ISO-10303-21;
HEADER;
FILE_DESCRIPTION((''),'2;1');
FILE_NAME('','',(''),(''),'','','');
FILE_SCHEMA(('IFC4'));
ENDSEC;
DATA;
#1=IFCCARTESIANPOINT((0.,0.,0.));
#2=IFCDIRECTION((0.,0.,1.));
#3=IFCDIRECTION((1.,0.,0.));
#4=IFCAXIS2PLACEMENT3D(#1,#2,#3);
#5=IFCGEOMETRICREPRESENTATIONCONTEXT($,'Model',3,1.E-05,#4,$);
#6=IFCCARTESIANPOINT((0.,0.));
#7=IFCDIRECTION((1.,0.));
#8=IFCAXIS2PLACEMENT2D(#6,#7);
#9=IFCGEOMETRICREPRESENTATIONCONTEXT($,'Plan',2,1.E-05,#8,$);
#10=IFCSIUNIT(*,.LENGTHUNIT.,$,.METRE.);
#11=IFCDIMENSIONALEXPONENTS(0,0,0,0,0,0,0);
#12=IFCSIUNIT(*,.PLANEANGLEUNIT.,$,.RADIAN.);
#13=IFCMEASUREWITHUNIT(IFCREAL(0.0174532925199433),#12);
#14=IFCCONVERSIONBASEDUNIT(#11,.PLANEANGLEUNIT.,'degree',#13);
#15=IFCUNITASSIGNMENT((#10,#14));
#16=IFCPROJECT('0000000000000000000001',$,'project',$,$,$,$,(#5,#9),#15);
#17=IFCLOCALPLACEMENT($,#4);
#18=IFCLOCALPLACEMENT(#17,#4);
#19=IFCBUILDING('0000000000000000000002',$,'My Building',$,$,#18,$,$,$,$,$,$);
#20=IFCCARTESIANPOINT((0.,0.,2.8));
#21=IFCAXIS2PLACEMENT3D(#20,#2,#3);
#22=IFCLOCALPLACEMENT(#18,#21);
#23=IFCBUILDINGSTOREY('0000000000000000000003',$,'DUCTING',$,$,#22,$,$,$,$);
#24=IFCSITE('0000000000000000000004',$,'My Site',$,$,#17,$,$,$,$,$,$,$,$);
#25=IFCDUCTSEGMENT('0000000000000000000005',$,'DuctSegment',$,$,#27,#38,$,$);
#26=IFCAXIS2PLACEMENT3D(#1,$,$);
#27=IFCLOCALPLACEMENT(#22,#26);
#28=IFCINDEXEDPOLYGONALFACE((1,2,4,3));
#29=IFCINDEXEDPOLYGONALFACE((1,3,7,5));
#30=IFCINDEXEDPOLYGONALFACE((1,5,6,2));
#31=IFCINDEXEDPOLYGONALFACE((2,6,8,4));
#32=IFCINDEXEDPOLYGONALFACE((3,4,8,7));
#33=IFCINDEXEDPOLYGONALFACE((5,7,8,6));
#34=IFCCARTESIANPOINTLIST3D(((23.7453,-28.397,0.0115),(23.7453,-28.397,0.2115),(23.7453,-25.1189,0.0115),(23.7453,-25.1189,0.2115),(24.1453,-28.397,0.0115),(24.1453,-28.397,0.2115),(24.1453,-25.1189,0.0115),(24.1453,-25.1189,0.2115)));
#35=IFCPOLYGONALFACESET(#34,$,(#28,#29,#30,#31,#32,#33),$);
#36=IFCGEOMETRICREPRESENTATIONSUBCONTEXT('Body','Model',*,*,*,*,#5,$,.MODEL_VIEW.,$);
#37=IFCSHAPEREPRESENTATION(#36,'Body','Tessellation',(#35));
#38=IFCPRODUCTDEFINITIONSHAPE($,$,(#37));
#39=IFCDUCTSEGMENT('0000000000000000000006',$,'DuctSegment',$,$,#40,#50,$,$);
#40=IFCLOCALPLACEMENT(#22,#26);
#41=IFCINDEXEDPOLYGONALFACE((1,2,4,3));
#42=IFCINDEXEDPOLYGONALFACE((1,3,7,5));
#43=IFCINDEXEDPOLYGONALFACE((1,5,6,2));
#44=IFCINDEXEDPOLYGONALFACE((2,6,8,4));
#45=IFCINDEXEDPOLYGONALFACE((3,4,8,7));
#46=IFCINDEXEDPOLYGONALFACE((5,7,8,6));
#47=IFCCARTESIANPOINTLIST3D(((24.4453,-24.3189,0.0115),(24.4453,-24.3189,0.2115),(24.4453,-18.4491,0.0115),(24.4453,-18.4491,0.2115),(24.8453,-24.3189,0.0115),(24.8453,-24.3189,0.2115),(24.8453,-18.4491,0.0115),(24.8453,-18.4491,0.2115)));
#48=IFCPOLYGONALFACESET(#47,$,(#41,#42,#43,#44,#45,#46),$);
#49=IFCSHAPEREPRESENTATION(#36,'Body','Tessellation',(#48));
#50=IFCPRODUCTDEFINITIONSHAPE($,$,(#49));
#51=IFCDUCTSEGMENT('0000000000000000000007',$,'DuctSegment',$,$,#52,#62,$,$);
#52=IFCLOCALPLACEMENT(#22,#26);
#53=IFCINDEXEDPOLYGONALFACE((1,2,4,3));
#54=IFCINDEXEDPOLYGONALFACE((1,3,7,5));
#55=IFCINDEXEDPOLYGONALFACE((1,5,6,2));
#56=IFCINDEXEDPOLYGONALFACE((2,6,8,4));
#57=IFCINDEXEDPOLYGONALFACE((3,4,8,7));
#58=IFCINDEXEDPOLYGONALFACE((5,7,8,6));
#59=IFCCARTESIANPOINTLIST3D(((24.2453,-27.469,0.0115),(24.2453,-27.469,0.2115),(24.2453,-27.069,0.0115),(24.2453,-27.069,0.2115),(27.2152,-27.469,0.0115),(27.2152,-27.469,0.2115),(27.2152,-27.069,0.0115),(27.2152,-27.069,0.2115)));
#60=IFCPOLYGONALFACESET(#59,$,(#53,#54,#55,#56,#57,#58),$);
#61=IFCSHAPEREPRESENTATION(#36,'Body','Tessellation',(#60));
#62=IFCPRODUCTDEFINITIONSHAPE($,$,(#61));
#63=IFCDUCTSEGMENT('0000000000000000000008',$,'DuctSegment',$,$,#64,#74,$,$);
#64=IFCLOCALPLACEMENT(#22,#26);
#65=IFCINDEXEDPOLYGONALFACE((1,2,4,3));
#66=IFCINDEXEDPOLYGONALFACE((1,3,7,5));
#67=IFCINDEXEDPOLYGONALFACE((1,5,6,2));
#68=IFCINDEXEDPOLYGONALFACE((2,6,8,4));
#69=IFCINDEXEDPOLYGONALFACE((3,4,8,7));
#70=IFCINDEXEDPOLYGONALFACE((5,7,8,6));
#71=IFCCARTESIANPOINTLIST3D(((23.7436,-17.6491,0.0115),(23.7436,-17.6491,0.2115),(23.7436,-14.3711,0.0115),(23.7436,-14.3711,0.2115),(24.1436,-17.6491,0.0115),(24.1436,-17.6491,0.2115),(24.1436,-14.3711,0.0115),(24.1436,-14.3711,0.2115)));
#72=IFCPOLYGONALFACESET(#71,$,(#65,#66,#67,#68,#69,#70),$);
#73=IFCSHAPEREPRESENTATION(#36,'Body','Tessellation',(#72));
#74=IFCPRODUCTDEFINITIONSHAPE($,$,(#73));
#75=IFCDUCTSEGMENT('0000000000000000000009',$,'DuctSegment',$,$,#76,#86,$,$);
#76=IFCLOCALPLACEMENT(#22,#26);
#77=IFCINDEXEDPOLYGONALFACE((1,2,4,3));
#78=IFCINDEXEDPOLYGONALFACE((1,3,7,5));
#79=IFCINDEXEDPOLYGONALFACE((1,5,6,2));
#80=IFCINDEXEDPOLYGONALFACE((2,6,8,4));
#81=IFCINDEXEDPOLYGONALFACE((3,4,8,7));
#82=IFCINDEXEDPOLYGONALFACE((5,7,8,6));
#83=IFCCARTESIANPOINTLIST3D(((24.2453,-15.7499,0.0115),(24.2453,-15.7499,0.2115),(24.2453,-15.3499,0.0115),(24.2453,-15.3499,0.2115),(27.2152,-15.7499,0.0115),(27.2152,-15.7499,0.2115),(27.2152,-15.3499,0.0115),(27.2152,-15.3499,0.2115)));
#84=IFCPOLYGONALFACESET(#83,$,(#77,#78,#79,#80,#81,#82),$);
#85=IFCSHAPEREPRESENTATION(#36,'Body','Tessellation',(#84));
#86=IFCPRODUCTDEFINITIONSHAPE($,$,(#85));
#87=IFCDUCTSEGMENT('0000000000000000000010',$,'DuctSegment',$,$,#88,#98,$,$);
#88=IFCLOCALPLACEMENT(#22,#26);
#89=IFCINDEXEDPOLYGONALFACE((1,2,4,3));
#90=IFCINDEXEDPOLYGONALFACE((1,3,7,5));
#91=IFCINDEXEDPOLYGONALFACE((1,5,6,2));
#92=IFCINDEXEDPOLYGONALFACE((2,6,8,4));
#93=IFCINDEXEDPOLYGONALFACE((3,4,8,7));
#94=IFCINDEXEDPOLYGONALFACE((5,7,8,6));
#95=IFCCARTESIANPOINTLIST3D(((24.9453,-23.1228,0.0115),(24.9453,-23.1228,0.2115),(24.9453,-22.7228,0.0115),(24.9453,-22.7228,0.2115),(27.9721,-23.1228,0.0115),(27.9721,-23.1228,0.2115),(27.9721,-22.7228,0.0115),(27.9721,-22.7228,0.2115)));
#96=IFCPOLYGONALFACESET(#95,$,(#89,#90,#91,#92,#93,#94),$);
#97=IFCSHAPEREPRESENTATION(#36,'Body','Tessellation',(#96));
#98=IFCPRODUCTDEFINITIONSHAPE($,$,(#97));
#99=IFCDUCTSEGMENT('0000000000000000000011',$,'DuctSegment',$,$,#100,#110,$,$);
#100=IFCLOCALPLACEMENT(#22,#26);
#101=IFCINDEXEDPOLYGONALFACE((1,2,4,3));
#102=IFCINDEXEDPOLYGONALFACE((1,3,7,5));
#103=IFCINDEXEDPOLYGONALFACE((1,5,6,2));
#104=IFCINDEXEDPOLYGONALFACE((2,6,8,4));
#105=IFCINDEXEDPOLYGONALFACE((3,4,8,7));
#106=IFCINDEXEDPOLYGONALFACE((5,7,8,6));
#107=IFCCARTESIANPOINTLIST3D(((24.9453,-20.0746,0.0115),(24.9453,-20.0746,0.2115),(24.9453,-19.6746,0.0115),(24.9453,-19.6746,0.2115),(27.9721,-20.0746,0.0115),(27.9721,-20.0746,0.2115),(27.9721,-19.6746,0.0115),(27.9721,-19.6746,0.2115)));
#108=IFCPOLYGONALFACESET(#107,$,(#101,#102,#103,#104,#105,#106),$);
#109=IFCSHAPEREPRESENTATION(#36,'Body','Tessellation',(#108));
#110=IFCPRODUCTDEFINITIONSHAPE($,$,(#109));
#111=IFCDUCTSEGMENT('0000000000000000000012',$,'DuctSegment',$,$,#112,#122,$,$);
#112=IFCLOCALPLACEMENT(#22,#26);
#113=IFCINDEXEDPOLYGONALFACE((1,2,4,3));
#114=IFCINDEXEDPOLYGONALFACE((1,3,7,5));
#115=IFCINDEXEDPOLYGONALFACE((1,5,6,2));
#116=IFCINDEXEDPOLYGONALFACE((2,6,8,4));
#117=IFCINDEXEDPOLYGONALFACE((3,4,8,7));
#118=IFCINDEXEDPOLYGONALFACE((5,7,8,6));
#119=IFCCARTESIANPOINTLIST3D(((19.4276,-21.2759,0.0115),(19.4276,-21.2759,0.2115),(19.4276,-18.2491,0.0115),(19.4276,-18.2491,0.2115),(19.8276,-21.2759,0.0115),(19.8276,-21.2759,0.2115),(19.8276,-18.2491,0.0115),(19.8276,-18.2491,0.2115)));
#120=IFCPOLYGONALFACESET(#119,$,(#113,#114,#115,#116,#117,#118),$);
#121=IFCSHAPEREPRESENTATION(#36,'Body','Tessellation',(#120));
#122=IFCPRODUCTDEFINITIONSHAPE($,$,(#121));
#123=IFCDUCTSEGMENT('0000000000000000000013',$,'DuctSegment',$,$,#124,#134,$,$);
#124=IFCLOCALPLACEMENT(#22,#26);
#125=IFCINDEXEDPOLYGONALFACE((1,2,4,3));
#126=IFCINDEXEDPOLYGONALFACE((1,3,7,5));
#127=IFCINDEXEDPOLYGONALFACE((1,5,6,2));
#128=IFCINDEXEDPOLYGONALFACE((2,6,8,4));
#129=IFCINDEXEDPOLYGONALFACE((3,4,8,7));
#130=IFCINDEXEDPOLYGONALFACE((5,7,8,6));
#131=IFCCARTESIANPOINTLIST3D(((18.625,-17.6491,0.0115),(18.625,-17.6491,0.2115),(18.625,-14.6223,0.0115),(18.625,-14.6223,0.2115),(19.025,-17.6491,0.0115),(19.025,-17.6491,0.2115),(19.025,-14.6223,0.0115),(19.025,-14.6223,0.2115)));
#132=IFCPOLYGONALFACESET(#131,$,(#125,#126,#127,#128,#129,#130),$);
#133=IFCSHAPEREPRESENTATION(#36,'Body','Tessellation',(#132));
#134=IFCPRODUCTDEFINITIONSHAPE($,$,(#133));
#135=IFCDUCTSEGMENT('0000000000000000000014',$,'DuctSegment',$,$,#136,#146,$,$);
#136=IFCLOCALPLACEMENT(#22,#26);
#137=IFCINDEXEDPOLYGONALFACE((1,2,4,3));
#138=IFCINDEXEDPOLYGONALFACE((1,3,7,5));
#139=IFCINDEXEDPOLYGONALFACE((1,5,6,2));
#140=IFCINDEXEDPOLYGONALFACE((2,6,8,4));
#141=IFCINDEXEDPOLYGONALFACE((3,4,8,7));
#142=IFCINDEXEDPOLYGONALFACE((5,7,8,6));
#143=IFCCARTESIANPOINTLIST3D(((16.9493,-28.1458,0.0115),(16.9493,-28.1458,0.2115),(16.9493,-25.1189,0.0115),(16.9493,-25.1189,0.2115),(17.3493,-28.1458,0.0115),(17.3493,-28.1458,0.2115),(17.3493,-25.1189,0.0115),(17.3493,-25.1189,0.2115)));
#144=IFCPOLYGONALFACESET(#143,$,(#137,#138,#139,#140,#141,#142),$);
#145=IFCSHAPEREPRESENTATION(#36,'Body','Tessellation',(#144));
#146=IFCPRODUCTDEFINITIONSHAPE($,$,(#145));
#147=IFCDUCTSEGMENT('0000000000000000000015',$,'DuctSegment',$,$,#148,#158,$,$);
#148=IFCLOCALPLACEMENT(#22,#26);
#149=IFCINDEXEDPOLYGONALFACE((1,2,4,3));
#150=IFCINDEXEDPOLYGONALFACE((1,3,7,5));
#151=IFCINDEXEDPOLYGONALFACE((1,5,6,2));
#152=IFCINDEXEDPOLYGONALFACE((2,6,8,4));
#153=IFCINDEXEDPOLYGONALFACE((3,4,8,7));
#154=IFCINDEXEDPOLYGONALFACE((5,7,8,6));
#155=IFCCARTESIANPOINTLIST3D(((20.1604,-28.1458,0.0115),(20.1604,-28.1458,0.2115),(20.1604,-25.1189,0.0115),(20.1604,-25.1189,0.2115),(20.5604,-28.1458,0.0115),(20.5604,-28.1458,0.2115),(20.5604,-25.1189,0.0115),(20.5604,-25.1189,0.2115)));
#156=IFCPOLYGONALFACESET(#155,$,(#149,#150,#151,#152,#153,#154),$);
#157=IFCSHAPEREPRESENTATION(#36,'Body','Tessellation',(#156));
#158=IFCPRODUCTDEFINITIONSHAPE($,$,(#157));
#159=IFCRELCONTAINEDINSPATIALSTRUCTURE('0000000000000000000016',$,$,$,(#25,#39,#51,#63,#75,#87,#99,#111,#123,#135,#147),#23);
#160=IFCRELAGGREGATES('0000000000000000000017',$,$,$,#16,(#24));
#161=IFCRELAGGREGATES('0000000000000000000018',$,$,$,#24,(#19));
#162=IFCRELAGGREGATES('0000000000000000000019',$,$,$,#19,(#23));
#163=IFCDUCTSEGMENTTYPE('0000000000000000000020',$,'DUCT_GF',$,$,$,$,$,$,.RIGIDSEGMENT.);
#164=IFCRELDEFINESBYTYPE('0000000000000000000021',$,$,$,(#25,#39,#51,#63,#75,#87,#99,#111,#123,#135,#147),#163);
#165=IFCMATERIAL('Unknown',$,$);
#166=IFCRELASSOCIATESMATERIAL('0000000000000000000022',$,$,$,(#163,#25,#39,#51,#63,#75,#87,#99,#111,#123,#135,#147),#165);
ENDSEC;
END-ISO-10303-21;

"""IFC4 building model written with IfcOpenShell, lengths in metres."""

from ifc_helpers import new_model, entity, si_unit, converted_unit, frame, origin_with_axes, origin_2d_with_axis, place, context, subcontext, project, spatial, rectangle, extrude, material, material_profile, profile_set, profile_usage, type_object, element, save


model = new_model("IFC4")

# Units and contexts
model_context = context("Model", 3, precision=1e-05, world=origin_with_axes())
plan_context = context("Plan", 2, precision=1e-05, world=origin_2d_with_axis())
body_context = subcontext(model_context, "Body", "Model", "MODEL_VIEW")
ifc_project = project(units=[si_unit("LENGTHUNIT", "METRE"), converted_unit("PLANEANGLEUNIT", "degree", entity("IfcReal", 0.0174532925199433), si_unit("PLANEANGLEUNIT", "RADIAN"), dimensions=[0, 0, 0, 0, 0, 0, 0])], contexts=[model_context, plan_context])

# Site, building, storey
site_placement = place(None, origin_with_axes())
site = spatial("IfcSite", under=ifc_project, at=site_placement, Name="My Site")
building_placement = place(site_placement, origin_with_axes())
building = spatial("IfcBuilding", under=site, at=building_placement, Name="My Building")
storey_placement = place(building_placement, frame((0.0, 0.0, 2.8), z_axis=(0.0, 0.0, 1.0), x_axis=(1.0, 0.0, 0.0)))
storey = spatial("IfcBuildingStorey", under=building, at=storey_placement, Name="DUCTING")

# Duct segments
ifc_material = material(Name="Unknown")
ifc_material_profile_1 = material_profile(ifc_material, rectangle(XDim=0.4, YDim=0.2))
ifc_profile_set_1 = profile_set([ifc_material_profile_1])
ifc_profile_usage_1 = profile_usage(ifc_profile_set_1, cardinal=5)
duct_segment_type = type_object("IfcDuctSegmentType", Name="DUCT_GF", PredefinedType="RIGIDSEGMENT", material=ifc_profile_set_1)
duct_segment_1_placement = place(storey_placement, frame((23.9453, -25.1189, 0.1115), z_axis=(0.0, -1.0, 0.0), x_axis=(1.0, 0.0, 0.0)))
element("IfcDuctSegment", 1, at=duct_segment_1_placement, inside=storey, type_object=duct_segment_type, material=ifc_profile_usage_1, Name="DuctSegment", context=body_context, shape_type="SweptSolid", body=[
    extrude(rectangle(XDim=0.4, YDim=0.2), origin_with_axes(), (0.0, 0.0, 1.0), 3.278),
])
ifc_profile_usage_2 = profile_usage(ifc_profile_set_1, cardinal=5)
duct_segment_2_placement = place(storey_placement, frame((24.6453, -18.4491, 0.1115), z_axis=(0.0, -1.0, 0.0), x_axis=(1.0, 0.0, 0.0)))
element("IfcDuctSegment", 2, at=duct_segment_2_placement, inside=storey, type_object=duct_segment_type, material=ifc_profile_usage_2, Name="DuctSegment", context=body_context, shape_type="SweptSolid", body=[
    extrude(rectangle(XDim=0.4, YDim=0.2), origin_with_axes(), (0.0, 0.0, 1.0), 5.8699),
])
ifc_profile_usage_3 = profile_usage(ifc_profile_set_1, cardinal=5)
duct_segment_3_placement = place(storey_placement, frame((24.2453, -27.269, 0.1115), z_axis=(1.0, 0.0, 0.0), x_axis=(0.0, 1.0, 0.0)))
element("IfcDuctSegment", 3, at=duct_segment_3_placement, inside=storey, type_object=duct_segment_type, material=ifc_profile_usage_3, Name="DuctSegment", context=body_context, shape_type="SweptSolid", body=[
    extrude(rectangle(XDim=0.4, YDim=0.2), origin_with_axes(), (0.0, 0.0, 1.0), 2.9699),
])
ifc_profile_usage_4 = profile_usage(ifc_profile_set_1, cardinal=5)
duct_segment_4_placement = place(storey_placement, frame((23.9436, -14.3711, 0.1115), z_axis=(0.000001, -1.0, 0.0), x_axis=(1.0, 0.000001, 0.0)))
element("IfcDuctSegment", 4, at=duct_segment_4_placement, inside=storey, type_object=duct_segment_type, material=ifc_profile_usage_4, Name="DuctSegment", context=body_context, shape_type="SweptSolid", body=[
    extrude(rectangle(XDim=0.4, YDim=0.2), origin_with_axes(), (0.0, 0.0, 1.0), 3.278),
])
ifc_profile_usage_5 = profile_usage(ifc_profile_set_1, cardinal=5)
duct_segment_5_placement = place(storey_placement, frame((24.2453, -15.5499, 0.1115), z_axis=(1.0, 0.0, 0.0), x_axis=(0.0, 1.0, 0.0)))
element("IfcDuctSegment", 5, at=duct_segment_5_placement, inside=storey, type_object=duct_segment_type, material=ifc_profile_usage_5, Name="DuctSegment", context=body_context, shape_type="SweptSolid", body=[
    extrude(rectangle(XDim=0.4, YDim=0.2), origin_with_axes(), (0.0, 0.0, 1.0), 2.9699),
])
ifc_profile_usage_6 = profile_usage(ifc_profile_set_1, cardinal=5)
duct_segment_6_placement = place(storey_placement, frame((24.9453, -22.9228, 0.1115), z_axis=(1.0, 0.0, 0.0), x_axis=(0.0, 1.0, 0.0)))
element("IfcDuctSegment", 6, at=duct_segment_6_placement, inside=storey, type_object=duct_segment_type, material=ifc_profile_usage_6, Name="DuctSegment", context=body_context, shape_type="SweptSolid", body=[
    extrude(rectangle(XDim=0.4, YDim=0.2), origin_with_axes(), (0.0, 0.0, 1.0), 3.0268),
])
ifc_profile_usage_7 = profile_usage(ifc_profile_set_1, cardinal=5)
duct_segment_7_placement = place(storey_placement, frame((24.9453, -19.8746, 0.1115), z_axis=(1.0, 0.0, 0.0), x_axis=(0.0, 1.0, 0.0)))
element("IfcDuctSegment", 7, at=duct_segment_7_placement, inside=storey, type_object=duct_segment_type, material=ifc_profile_usage_7, Name="DuctSegment", context=body_context, shape_type="SweptSolid", body=[
    extrude(rectangle(XDim=0.4, YDim=0.2), origin_with_axes(), (0.0, 0.0, 1.0), 3.0268),
])
ifc_profile_usage_8 = profile_usage(ifc_profile_set_1, cardinal=5)
duct_segment_8_placement = place(storey_placement, frame((19.6276, -18.2491, 0.1115), z_axis=(0.000001, -1.0, 0.0), x_axis=(1.0, 0.000001, 0.0)))
element("IfcDuctSegment", 8, at=duct_segment_8_placement, inside=storey, type_object=duct_segment_type, material=ifc_profile_usage_8, Name="DuctSegment", context=body_context, shape_type="SweptSolid", body=[
    extrude(rectangle(XDim=0.4, YDim=0.2), origin_with_axes(), (0.0, 0.0, 1.0), 3.0268),
])
ifc_profile_usage_9 = profile_usage(ifc_profile_set_1, cardinal=5)
duct_segment_9_placement = place(storey_placement, frame((18.825, -14.6223, 0.1115), z_axis=(0.000001, -1.0, 0.0), x_axis=(1.0, 0.000001, 0.0)))
element("IfcDuctSegment", 9, at=duct_segment_9_placement, inside=storey, type_object=duct_segment_type, material=ifc_profile_usage_9, Name="DuctSegment", context=body_context, shape_type="SweptSolid", body=[
    extrude(rectangle(XDim=0.4, YDim=0.2), origin_with_axes(), (0.0, 0.0, 1.0), 3.0268),
])
ifc_profile_usage_10 = profile_usage(ifc_profile_set_1, cardinal=5)
duct_segment_10_placement = place(storey_placement, frame((17.1493, -25.1189, 0.1115), z_axis=(0.000001, -1.0, 0.0), x_axis=(1.0, 0.000001, 0.0)))
element("IfcDuctSegment", 10, at=duct_segment_10_placement, inside=storey, type_object=duct_segment_type, material=ifc_profile_usage_10, Name="DuctSegment", context=body_context, shape_type="SweptSolid", body=[
    extrude(rectangle(XDim=0.4, YDim=0.2), origin_with_axes(), (0.0, 0.0, 1.0), 3.0268),
])
ifc_profile_usage_11 = profile_usage(ifc_profile_set_1, cardinal=5)
duct_segment_11_placement = place(storey_placement, frame((20.3604, -25.1189, 0.1115), z_axis=(0.000001, -1.0, 0.0), x_axis=(1.0, 0.000001, 0.0)))
element("IfcDuctSegment", 11, at=duct_segment_11_placement, inside=storey, type_object=duct_segment_type, material=ifc_profile_usage_11, Name="DuctSegment", context=body_context, shape_type="SweptSolid", body=[
    extrude(rectangle(XDim=0.4, YDim=0.2), origin_with_axes(), (0.0, 0.0, 1.0), 3.0268),
])

save(model, "model.ifc")
